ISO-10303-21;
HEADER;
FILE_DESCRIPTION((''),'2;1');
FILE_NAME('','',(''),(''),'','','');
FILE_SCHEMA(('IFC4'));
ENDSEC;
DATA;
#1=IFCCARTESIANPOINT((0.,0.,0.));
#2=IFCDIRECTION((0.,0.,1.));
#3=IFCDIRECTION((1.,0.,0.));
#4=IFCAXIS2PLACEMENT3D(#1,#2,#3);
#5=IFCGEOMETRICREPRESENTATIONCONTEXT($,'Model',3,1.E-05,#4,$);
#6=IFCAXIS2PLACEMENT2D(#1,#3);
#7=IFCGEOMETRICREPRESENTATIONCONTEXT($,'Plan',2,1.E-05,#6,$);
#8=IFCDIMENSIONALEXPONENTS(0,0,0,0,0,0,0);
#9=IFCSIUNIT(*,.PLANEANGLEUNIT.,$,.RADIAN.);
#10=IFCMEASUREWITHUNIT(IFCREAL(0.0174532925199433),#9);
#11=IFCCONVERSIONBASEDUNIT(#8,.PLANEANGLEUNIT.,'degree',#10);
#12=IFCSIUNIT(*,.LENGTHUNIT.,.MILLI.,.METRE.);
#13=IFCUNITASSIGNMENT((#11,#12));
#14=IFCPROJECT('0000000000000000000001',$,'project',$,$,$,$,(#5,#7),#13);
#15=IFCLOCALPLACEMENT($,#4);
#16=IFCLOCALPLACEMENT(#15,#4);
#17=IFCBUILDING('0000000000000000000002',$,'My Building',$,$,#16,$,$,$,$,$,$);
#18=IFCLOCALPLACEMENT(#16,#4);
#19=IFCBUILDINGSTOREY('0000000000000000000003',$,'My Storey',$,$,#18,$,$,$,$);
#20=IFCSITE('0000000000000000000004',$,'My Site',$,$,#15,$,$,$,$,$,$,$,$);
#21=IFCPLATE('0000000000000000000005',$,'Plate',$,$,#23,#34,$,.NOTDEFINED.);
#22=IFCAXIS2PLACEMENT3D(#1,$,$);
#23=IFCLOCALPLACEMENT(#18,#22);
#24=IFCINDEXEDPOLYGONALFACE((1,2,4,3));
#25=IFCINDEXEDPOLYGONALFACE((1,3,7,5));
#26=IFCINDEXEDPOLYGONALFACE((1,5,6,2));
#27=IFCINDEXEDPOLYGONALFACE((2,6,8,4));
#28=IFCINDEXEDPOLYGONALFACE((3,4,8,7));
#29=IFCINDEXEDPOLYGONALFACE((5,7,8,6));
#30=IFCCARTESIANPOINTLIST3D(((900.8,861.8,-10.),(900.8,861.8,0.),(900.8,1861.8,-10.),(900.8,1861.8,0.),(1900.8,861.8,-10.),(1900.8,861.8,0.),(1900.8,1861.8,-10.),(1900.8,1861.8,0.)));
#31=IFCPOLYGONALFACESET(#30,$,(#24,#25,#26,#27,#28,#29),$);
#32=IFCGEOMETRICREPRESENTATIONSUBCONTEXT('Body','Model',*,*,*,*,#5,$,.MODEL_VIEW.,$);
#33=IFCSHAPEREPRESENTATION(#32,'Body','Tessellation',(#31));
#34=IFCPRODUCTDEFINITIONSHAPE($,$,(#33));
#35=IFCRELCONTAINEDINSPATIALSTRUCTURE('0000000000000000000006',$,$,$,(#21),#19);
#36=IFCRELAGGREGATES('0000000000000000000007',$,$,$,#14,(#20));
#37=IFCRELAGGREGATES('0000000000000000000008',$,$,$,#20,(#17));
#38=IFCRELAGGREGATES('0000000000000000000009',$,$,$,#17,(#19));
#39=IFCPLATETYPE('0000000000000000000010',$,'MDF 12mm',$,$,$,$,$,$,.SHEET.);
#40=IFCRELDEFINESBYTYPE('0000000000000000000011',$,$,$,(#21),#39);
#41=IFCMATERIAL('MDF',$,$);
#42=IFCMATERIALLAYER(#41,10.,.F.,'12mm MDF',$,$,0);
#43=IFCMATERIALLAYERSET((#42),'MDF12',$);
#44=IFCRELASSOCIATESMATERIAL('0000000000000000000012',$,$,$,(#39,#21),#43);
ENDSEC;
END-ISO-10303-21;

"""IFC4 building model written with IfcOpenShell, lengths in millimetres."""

from ifc_helpers import new_model, entity, si_unit, converted_unit, frame, frame_2d, origin_with_axes, place, context, subcontext, project, spatial, indexed_curve, outline, extrude, material, layer, layer_set, layer_usage, type_object, element, save


model = new_model("IFC4")

# Units and contexts
model_context = context("Model", 3, precision=1e-05, world=origin_with_axes())
plan_context = context("Plan", 2, precision=1e-05, world=frame_2d((0.0, 0.0, 0.0), x_axis=(1.0, 0.0, 0.0)))
body_context = subcontext(model_context, "Body", "Model", "MODEL_VIEW")
ifc_project = project(units=[converted_unit("PLANEANGLEUNIT", "degree", entity("IfcReal", 0.0174532925199433), si_unit("PLANEANGLEUNIT", "RADIAN"), dimensions=[0, 0, 0, 0, 0, 0, 0]), si_unit("LENGTHUNIT", "METRE", prefix="MILLI")], contexts=[model_context, plan_context])

# Site, building, storey
site_placement = place(None, origin_with_axes())
site = spatial("IfcSite", under=ifc_project, at=site_placement, Name="My Site")
building_placement = place(site_placement, origin_with_axes())
building = spatial("IfcBuilding", under=site, at=building_placement, Name="My Building")
storey_placement = place(building_placement, origin_with_axes())
storey = spatial("IfcBuildingStorey", under=building, at=storey_placement, Name="My Storey")

# Plate
ifc_material = material(Name="MDF")
ifc_layer = layer(ifc_material, 10.0, ventilated=False, Name="12mm MDF", Priority=0)
ifc_layer_set = layer_set([ifc_layer], Name="MDF12")
ifc_layer_usage = layer_usage(ifc_layer_set, "AXIS3", "POSITIVE", 0.0)
plate_type = type_object("IfcPlateType", Name="MDF 12mm", PredefinedType="SHEET", material=ifc_layer_set)
plate_placement = place(storey_placement, frame((900.8, 861.8, -10.0), z_axis=(0.0, 0.0, 1.0), x_axis=(1.0, 0.0, 0.0)))
element("IfcPlate", 1, at=plate_placement, inside=storey, type_object=plate_type, material=ifc_layer_usage, Name="Plate", PredefinedType="NOTDEFINED", context=body_context, shape_type="SweptSolid", body=[
    extrude(outline(indexed_curve([(0.0, 0.0), (1000.0, 0.0), (1000.0, 1000.0), (0.0, 1000.0), (0.0, 0.0)])), None, (0.0, 0.0, 1.0), 10.0),
])

save(model, "model.ifc")
